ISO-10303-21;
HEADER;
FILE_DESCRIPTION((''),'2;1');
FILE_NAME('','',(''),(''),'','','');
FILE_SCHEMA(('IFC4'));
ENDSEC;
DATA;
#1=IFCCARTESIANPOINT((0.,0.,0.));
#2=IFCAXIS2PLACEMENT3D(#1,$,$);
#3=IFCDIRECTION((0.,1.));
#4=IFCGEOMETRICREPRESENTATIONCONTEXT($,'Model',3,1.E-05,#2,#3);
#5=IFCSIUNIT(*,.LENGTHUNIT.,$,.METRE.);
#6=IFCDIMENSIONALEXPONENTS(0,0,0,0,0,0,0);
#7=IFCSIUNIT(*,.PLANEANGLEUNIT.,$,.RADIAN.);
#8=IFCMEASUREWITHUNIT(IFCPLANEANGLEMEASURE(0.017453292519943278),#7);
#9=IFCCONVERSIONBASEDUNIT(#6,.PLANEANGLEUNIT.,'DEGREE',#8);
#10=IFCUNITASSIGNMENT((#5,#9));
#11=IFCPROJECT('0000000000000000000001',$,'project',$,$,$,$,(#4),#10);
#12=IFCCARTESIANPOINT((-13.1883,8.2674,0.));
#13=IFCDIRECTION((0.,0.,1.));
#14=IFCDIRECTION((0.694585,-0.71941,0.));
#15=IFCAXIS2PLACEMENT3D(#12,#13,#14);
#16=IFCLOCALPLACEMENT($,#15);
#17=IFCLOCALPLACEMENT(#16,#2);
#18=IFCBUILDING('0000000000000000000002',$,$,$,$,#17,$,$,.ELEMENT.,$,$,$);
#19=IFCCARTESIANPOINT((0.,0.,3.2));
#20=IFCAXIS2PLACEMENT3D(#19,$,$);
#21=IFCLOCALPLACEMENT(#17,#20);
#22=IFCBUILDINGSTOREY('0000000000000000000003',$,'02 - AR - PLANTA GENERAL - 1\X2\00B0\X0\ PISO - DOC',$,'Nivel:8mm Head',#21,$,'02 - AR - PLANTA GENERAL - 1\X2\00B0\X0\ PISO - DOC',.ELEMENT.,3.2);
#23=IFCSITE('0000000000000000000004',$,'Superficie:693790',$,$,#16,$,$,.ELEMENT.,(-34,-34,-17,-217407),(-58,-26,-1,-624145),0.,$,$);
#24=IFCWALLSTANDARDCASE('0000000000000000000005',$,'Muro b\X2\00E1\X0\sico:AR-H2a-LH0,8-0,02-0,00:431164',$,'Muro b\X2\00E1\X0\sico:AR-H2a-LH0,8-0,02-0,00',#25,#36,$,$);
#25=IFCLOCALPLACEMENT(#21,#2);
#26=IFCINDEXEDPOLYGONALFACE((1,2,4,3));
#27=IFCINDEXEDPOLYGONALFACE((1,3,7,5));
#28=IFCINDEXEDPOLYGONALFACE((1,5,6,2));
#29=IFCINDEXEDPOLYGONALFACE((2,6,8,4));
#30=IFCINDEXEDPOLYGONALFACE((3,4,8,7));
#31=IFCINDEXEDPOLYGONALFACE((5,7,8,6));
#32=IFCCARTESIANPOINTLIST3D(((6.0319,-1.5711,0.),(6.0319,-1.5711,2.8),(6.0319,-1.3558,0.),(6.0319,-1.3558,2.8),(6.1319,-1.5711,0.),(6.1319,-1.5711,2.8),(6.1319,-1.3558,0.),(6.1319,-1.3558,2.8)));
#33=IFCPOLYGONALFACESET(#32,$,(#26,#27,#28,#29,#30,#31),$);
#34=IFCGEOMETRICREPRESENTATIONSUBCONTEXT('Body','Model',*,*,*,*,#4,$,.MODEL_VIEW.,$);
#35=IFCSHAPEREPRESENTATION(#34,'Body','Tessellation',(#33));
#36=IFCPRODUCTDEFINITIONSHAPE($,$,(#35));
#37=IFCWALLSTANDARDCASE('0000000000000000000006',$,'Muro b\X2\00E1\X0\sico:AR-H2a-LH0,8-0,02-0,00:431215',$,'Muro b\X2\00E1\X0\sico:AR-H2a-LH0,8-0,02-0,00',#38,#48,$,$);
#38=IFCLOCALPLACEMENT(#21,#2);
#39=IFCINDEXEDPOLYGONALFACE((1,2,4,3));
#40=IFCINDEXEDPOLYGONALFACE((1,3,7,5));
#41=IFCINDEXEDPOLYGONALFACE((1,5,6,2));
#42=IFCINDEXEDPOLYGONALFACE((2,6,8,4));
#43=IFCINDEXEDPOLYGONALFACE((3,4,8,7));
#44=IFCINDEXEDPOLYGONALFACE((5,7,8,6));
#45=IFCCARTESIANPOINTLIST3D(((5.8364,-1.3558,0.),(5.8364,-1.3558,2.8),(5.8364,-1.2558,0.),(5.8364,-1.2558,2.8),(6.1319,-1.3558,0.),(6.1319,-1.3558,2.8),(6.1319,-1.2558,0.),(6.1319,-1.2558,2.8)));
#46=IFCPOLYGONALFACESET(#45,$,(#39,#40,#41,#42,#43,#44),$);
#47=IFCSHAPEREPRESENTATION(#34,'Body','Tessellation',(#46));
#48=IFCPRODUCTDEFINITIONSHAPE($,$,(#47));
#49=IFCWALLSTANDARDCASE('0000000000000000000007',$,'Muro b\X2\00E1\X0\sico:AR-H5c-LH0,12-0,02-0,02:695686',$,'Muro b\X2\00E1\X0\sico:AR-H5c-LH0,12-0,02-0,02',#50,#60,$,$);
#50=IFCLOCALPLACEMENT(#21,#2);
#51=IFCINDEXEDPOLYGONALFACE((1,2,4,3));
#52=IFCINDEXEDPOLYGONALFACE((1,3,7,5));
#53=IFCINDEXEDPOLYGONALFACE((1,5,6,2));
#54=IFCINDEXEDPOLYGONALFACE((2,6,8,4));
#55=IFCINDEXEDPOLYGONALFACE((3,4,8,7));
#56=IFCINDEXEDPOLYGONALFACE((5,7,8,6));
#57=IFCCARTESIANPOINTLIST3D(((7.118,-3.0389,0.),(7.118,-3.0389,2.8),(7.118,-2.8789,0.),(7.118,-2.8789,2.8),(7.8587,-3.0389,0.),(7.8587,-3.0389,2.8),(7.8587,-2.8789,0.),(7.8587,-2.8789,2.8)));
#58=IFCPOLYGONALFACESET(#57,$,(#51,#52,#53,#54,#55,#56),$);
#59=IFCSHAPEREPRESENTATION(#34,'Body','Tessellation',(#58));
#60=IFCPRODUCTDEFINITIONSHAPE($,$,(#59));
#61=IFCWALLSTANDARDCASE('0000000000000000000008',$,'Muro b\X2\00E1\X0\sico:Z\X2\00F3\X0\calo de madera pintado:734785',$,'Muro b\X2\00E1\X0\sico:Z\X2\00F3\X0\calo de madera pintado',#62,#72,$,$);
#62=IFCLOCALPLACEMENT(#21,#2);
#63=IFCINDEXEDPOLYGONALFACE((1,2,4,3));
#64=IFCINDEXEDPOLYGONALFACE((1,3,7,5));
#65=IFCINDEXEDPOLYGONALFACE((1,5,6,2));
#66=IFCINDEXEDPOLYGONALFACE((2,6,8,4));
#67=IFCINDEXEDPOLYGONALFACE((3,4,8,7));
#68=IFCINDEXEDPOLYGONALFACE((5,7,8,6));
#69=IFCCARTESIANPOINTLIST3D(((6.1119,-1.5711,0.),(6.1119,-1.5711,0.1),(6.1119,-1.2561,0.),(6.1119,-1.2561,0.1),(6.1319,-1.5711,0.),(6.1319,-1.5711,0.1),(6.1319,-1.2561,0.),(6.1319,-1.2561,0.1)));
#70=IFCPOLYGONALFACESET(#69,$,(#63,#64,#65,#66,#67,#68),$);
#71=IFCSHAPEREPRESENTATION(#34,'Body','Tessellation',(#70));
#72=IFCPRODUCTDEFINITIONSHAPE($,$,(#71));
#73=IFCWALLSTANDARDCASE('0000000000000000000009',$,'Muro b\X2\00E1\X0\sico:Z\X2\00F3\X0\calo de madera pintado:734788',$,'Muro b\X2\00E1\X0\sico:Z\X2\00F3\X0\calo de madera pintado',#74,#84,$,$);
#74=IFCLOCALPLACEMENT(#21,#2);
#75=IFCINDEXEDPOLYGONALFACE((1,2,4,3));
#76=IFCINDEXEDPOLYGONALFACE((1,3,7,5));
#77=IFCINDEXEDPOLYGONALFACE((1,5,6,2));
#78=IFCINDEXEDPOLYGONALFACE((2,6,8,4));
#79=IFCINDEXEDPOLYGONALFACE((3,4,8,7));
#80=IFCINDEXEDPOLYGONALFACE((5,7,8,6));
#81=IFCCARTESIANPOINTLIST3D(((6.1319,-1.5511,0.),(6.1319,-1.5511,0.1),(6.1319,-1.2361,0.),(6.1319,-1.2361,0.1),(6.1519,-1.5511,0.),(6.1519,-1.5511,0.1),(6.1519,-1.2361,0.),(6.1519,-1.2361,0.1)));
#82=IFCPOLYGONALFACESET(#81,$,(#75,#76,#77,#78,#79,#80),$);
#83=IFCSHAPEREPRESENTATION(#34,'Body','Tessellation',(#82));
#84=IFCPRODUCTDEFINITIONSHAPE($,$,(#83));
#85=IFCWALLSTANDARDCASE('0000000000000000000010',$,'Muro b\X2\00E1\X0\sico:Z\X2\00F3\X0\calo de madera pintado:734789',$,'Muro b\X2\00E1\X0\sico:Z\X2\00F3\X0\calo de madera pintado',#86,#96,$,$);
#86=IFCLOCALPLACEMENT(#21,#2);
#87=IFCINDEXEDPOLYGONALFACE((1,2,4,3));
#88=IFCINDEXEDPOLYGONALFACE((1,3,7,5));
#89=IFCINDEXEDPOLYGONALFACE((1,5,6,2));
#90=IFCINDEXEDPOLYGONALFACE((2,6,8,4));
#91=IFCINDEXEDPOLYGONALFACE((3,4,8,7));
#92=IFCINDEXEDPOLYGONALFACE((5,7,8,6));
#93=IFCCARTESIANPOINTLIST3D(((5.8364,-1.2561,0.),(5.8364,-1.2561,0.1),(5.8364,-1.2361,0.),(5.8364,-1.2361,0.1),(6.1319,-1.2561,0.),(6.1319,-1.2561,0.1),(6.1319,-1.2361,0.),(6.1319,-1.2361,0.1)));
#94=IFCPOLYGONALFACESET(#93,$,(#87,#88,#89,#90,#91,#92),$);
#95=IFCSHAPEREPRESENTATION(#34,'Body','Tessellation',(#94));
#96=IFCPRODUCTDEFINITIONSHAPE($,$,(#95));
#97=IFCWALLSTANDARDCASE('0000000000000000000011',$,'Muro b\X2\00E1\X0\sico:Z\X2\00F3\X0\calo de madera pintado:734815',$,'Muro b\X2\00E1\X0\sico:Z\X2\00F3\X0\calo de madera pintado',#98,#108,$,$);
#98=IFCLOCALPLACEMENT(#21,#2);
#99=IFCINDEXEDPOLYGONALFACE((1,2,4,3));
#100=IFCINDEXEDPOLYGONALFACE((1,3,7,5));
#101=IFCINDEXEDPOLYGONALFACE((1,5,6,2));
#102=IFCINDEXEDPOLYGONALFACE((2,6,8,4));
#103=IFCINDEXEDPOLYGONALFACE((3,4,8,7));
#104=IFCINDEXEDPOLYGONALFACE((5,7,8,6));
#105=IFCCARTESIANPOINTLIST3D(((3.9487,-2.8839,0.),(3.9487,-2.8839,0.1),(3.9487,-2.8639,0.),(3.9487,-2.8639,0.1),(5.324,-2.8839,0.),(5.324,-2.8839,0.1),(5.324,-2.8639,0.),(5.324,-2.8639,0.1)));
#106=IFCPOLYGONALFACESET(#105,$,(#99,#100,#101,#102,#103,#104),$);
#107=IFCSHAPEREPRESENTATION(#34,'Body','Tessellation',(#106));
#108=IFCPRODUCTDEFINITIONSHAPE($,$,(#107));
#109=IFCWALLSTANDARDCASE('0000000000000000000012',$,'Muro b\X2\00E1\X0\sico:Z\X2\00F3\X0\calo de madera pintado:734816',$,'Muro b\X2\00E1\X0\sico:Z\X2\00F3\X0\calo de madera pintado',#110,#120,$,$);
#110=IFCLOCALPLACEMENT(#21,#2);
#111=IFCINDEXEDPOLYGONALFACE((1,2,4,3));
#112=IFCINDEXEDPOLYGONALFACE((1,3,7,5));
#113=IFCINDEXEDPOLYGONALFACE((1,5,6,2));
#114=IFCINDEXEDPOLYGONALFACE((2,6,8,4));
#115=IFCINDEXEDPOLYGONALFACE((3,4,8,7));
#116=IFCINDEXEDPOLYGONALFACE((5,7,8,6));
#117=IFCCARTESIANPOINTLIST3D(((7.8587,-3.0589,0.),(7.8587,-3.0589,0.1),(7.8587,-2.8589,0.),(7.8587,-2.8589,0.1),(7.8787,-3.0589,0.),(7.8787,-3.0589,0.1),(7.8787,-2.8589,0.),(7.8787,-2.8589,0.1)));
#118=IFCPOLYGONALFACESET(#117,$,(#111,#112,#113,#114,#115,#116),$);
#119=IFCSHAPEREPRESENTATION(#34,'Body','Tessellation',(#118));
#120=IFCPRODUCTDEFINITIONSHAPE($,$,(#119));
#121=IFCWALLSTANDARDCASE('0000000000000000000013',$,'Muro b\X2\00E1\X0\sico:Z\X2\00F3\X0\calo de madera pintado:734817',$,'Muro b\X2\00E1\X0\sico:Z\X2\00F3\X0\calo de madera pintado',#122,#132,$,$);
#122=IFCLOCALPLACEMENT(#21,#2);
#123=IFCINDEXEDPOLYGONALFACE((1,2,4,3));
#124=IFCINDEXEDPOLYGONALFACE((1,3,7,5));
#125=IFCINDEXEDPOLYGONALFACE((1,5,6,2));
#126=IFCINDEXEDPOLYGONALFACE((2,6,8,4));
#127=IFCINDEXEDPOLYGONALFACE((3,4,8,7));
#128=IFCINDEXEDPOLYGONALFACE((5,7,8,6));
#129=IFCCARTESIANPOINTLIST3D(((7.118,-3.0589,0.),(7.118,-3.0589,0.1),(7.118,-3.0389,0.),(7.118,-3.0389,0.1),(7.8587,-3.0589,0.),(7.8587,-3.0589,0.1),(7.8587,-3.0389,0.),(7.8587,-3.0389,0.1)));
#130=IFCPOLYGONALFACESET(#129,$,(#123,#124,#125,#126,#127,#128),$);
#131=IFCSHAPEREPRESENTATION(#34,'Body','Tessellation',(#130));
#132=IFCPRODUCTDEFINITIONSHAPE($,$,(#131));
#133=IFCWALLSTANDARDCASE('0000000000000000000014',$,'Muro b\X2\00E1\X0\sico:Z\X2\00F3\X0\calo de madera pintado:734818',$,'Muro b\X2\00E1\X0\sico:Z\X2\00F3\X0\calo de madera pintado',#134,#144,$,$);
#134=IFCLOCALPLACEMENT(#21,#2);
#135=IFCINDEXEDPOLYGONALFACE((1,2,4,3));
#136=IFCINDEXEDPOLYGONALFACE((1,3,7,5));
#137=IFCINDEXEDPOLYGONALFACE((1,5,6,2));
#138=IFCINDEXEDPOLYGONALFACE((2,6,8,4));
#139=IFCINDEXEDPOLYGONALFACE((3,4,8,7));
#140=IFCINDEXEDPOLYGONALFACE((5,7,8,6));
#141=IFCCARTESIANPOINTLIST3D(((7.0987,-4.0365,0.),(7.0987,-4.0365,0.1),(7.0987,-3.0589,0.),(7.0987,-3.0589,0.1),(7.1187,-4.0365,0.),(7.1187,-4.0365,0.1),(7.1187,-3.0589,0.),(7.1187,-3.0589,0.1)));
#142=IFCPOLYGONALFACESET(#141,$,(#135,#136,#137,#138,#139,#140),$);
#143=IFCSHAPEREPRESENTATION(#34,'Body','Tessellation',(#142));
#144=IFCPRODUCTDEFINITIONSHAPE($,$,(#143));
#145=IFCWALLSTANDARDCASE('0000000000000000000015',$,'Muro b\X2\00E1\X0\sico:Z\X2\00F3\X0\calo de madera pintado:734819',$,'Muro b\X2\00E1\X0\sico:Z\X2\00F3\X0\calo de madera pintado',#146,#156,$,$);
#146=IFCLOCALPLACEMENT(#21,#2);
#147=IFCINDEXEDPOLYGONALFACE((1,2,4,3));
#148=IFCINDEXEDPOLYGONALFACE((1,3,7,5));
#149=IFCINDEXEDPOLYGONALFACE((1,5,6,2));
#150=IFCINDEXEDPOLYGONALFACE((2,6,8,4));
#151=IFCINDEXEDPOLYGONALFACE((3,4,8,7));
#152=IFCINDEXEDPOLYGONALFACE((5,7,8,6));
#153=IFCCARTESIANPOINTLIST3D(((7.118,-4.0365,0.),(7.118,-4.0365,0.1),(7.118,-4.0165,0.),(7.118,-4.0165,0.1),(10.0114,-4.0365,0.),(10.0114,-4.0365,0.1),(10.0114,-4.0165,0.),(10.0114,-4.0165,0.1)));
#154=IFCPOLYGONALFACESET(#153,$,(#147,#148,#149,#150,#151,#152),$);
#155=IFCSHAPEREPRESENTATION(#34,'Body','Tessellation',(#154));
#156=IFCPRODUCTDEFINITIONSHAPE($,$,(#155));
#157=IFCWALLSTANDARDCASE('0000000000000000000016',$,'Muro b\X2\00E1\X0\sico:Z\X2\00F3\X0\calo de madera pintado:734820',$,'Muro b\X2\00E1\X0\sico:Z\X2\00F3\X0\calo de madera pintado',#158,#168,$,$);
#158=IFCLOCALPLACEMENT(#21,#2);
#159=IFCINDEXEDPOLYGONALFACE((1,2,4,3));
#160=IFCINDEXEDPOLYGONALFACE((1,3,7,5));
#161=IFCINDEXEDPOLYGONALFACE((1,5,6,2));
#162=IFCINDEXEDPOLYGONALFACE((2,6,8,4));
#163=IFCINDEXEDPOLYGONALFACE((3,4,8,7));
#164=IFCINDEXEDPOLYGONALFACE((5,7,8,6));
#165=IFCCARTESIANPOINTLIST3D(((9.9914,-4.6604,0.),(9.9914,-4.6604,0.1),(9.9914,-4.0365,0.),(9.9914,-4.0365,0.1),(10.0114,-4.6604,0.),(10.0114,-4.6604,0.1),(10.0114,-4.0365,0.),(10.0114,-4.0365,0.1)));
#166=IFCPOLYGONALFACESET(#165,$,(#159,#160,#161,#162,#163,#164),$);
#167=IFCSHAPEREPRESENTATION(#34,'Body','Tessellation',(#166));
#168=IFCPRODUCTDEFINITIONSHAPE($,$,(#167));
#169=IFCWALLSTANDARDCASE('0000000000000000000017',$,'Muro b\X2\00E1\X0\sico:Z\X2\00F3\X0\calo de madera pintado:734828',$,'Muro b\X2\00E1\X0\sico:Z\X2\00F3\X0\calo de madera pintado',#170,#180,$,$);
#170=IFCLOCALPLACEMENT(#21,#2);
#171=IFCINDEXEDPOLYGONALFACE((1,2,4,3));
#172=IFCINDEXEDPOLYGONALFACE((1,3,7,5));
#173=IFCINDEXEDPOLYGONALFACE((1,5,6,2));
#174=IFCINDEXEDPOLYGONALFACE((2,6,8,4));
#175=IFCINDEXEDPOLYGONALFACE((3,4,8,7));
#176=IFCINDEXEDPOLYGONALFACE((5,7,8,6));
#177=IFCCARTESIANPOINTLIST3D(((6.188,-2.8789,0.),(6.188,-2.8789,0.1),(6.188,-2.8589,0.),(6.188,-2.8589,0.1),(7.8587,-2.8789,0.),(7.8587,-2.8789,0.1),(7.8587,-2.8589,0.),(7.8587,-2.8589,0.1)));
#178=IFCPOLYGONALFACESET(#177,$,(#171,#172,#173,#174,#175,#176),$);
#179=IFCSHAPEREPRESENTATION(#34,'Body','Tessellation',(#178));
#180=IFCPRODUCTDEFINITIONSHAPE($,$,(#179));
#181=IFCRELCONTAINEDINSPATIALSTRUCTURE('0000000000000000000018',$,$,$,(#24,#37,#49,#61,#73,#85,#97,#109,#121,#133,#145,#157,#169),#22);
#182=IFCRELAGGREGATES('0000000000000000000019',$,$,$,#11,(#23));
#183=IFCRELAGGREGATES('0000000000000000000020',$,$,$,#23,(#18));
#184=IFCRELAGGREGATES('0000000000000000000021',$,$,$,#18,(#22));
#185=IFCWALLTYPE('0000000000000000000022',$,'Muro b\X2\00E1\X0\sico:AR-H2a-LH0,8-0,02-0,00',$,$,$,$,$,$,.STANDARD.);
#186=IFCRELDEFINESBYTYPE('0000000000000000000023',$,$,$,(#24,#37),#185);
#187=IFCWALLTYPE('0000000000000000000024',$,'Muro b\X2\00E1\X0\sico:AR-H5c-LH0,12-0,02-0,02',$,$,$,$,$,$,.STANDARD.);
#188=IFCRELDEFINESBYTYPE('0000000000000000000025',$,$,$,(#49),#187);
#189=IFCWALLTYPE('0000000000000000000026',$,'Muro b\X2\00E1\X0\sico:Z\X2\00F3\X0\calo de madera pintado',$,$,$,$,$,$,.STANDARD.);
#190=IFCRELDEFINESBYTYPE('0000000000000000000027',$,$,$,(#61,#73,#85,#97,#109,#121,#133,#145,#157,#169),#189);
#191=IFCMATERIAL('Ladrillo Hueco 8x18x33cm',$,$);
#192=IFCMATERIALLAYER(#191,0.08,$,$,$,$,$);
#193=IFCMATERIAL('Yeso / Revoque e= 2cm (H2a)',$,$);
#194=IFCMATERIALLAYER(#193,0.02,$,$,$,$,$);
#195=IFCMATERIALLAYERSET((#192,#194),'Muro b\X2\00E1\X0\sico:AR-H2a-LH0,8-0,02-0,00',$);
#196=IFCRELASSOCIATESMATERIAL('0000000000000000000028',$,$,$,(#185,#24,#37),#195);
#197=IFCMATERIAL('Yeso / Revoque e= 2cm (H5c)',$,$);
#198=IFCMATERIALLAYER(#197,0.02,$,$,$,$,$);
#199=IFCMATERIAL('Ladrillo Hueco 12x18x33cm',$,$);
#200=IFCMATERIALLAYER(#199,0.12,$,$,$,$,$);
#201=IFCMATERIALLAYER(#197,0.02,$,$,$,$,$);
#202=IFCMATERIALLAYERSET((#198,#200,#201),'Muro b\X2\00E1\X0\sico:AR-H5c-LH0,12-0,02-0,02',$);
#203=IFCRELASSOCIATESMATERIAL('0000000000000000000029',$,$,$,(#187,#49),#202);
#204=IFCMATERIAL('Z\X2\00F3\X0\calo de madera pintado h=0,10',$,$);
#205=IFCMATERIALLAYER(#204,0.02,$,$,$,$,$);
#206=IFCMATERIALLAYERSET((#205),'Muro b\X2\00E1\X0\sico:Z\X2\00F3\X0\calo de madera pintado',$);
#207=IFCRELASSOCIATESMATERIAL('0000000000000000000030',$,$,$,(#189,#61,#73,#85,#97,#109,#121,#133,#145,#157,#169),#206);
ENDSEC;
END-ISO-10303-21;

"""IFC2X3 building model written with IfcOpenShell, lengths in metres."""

from ifc_helpers import new_model, entity, si_unit, converted_unit, direction, frame, frame_2d, origin, place, context, subcontext, project, spatial, rectangle, extrude, material, layer, layer_set, layer_usage, type_object, element, save


model = new_model("IFC2X3")

# Units and contexts
model_context = context("Model", 3, precision=1e-05, world=origin(), true_north=direction((0.0, 1.0)))
body_context = subcontext(model_context, "Body", "Model", "MODEL_VIEW")
ifc_project = project(units=[si_unit("LENGTHUNIT", "METRE"), converted_unit("PLANEANGLEUNIT", "DEGREE", entity("IfcPlaneAngleMeasure", 0.017453292519943278), si_unit("PLANEANGLEUNIT", "RADIAN"), dimensions=[0, 0, 0, 0, 0, 0, 0])], contexts=[model_context])

# Site, building, storey
site_placement = place(None, frame((-13.1883, 8.2674, 0.0), z_axis=(0.0, 0.0, 1.0), x_axis=(0.694585, -0.71941, 0.0)))
site = spatial("IfcSite", under=ifc_project, at=site_placement, Name="Superficie:693790", CompositionType="ELEMENT", RefLatitude=(-34, -34, -17, -217407), RefLongitude=(-58, -26, -1, -624145), RefElevation=0.0)
building_placement = place(site_placement, origin())
building = spatial("IfcBuilding", under=site, at=building_placement, CompositionType="ELEMENT")
storey_placement = place(building_placement, frame((0.0, 0.0, 3.2)))
storey = spatial("IfcBuildingStorey", under=building, at=storey_placement, Name="02 - AR - PLANTA GENERAL - 1° PISO - DOC", ObjectType="Nivel:8mm Head", LongName="02 - AR - PLANTA GENERAL - 1° PISO - DOC", CompositionType="ELEMENT", Elevation=3.2)

# Shared definitions
ifc_material_1 = material(Name="Ladrillo Hueco 8x18x33cm")

# Walls
ifc_layer_1 = layer(ifc_material_1, 0.08)
ifc_material_2 = material(Name="Yeso / Revoque e= 2cm (H2a)")
ifc_layer_2 = layer(ifc_material_2, 0.02)
ifc_layer_set_1 = layer_set([ifc_layer_1, ifc_layer_2], Name="Muro básico:AR-H2a-LH0,8-0,02-0,00")
wall_type_1 = type_object("IfcWallType", Name="Muro básico:AR-H2a-LH0,8-0,02-0,00", PredefinedType="STANDARD", material=ifc_layer_set_1)
ifc_layer_usage_1 = layer_usage(ifc_layer_set_1, "AXIS2", "NEGATIVE", 0.05)
wall_1_placement = place(storey_placement, frame((6.0819, -1.5711, 0.0), z_axis=(0.0, 0.0, 1.0), x_axis=(0.0, 1.0, 0.0)))
element("IfcWallStandardCase", 1, at=wall_1_placement, inside=storey, type_object=wall_type_1, material=ifc_layer_usage_1, Name="Muro básico:AR-H2a-LH0,8-0,02-0,00:431164", ObjectType="Muro básico:AR-H2a-LH0,8-0,02-0,00", context=body_context, shape_type="SweptSolid", body=[
    extrude(rectangle(XDim=0.2153, YDim=0.1, at=frame_2d((0.1076, 0.0), x_axis=(-1.0, 0.0))), origin(), (0.0, 0.0, 1.0), 2.8),
])
ifc_layer_usage_2 = layer_usage(ifc_layer_set_1, "AXIS2", "NEGATIVE", 0.05)
wall_2_placement = place(storey_placement, frame((6.1319, -1.3058, 0.0), z_axis=(0.0, 0.0, 1.0), x_axis=(-1.0, 0.0, 0.0)))
element("IfcWallStandardCase", 2, at=wall_2_placement, inside=storey, type_object=wall_type_1, material=ifc_layer_usage_2, Name="Muro básico:AR-H2a-LH0,8-0,02-0,00:431215", ObjectType="Muro básico:AR-H2a-LH0,8-0,02-0,00", context=body_context, shape_type="SweptSolid", body=[
    extrude(rectangle(XDim=0.2955, YDim=0.1, at=frame_2d((0.1477, 0.0), x_axis=(-1.0, 0.0))), origin(), (0.0, 0.0, 1.0), 2.8),
])
ifc_material_3 = material(Name="Yeso / Revoque e= 2cm (H5c)")
ifc_layer_3 = layer(ifc_material_3, 0.02)
ifc_material_4 = material(Name="Ladrillo Hueco 12x18x33cm")
ifc_layer_4 = layer(ifc_material_4, 0.12)
ifc_layer_5 = layer(ifc_material_3, 0.02)
ifc_layer_set_2 = layer_set([ifc_layer_3, ifc_layer_4, ifc_layer_5], Name="Muro básico:AR-H5c-LH0,12-0,02-0,02")
ifc_layer_usage_3 = layer_usage(ifc_layer_set_2, "AXIS2", "NEGATIVE", 0.08)
wall_type_2 = type_object("IfcWallType", Name="Muro básico:AR-H5c-LH0,12-0,02-0,02", PredefinedType="STANDARD", material=ifc_layer_set_2)
wall_3_placement = place(storey_placement, frame((7.118, -2.9589, 0.0)))
element("IfcWallStandardCase", 3, at=wall_3_placement, inside=storey, type_object=wall_type_2, material=ifc_layer_usage_3, Name="Muro básico:AR-H5c-LH0,12-0,02-0,02:695686", ObjectType="Muro básico:AR-H5c-LH0,12-0,02-0,02", context=body_context, shape_type="SweptSolid", body=[
    extrude(rectangle(XDim=0.7407, YDim=0.16, at=frame_2d((0.3704, 0.0), x_axis=(-1.0, 0.0))), origin(), (0.0, 0.0, 1.0), 2.8),
])
ifc_material_5 = material(Name="Zócalo de madera pintado h=0,10")
ifc_layer_6 = layer(ifc_material_5, 0.02)
ifc_layer_set_3 = layer_set([ifc_layer_6], Name="Muro básico:Zócalo de madera pintado")
ifc_layer_usage_4 = layer_usage(ifc_layer_set_3, "AXIS2", "NEGATIVE", 0.01)
wall_type_3 = type_object("IfcWallType", Name="Muro básico:Zócalo de madera pintado", PredefinedType="STANDARD", material=ifc_layer_set_3)
wall_4_placement = place(storey_placement, frame((6.1219, -1.2561, 0.0), z_axis=(0.0, 0.0, 1.0), x_axis=(0.0, -1.0, 0.0)))
element("IfcWallStandardCase", 4, at=wall_4_placement, inside=storey, type_object=wall_type_3, material=ifc_layer_usage_4, Name="Muro básico:Zócalo de madera pintado:734785", ObjectType="Muro básico:Zócalo de madera pintado", context=body_context, shape_type="SweptSolid", body=[
    extrude(rectangle(XDim=0.315, YDim=0.02, at=frame_2d((0.1575, 0.0), x_axis=(-1.0, 0.0))), origin(), (0.0, 0.0, 1.0), 0.1),
])
ifc_layer_usage_5 = layer_usage(ifc_layer_set_3, "AXIS2", "NEGATIVE", 0.01)
wall_5_placement = place(storey_placement, frame((6.1419, -1.5511, 0.0), z_axis=(0.0, 0.0, 1.0), x_axis=(0.0, 1.0, 0.0)))
element("IfcWallStandardCase", 5, at=wall_5_placement, inside=storey, type_object=wall_type_3, material=ifc_layer_usage_5, Name="Muro básico:Zócalo de madera pintado:734788", ObjectType="Muro básico:Zócalo de madera pintado", context=body_context, shape_type="SweptSolid", body=[
    extrude(rectangle(XDim=0.315, YDim=0.02, at=frame_2d((0.1575, 0.0), x_axis=(-1.0, 0.0))), origin(), (0.0, 0.0, 1.0), 0.1),
])
ifc_layer_usage_6 = layer_usage(ifc_layer_set_3, "AXIS2", "NEGATIVE", 0.01)
wall_6_placement = place(storey_placement, frame((6.1319, -1.2461, 0.0), z_axis=(0.0, 0.0, 1.0), x_axis=(-1.0, 0.0, 0.0)))
element("IfcWallStandardCase", 6, at=wall_6_placement, inside=storey, type_object=wall_type_3, material=ifc_layer_usage_6, Name="Muro básico:Zócalo de madera pintado:734789", ObjectType="Muro básico:Zócalo de madera pintado", context=body_context, shape_type="SweptSolid", body=[
    extrude(rectangle(XDim=0.2955, YDim=0.02, at=frame_2d((0.1477, 0.0), x_axis=(-1.0, 0.0))), origin(), (0.0, 0.0, 1.0), 0.1),
])
ifc_layer_usage_7 = layer_usage(ifc_layer_set_3, "AXIS2", "NEGATIVE", 0.01)
wall_7_placement = place(storey_placement, frame((5.324, -2.8739, 0.0), z_axis=(0.0, 0.0, 1.0), x_axis=(-1.0, 0.0, 0.0)))
element("IfcWallStandardCase", 7, at=wall_7_placement, inside=storey, type_object=wall_type_3, material=ifc_layer_usage_7, Name="Muro básico:Zócalo de madera pintado:734815", ObjectType="Muro básico:Zócalo de madera pintado", context=body_context, shape_type="SweptSolid", body=[
    extrude(rectangle(XDim=1.3753, YDim=0.02, at=frame_2d((0.6876, 0.0), x_axis=(-1.0, 0.0))), origin(), (0.0, 0.0, 1.0), 0.1),
])
ifc_layer_usage_8 = layer_usage(ifc_layer_set_3, "AXIS2", "NEGATIVE", 0.01)
wall_8_placement = place(storey_placement, frame((7.8687, -3.0589, 0.0), z_axis=(0.0, 0.0, 1.0), x_axis=(0.0, 1.0, 0.0)))
element("IfcWallStandardCase", 8, at=wall_8_placement, inside=storey, type_object=wall_type_3, material=ifc_layer_usage_8, Name="Muro básico:Zócalo de madera pintado:734816", ObjectType="Muro básico:Zócalo de madera pintado", context=body_context, shape_type="SweptSolid", body=[
    extrude(rectangle(XDim=0.2, YDim=0.02, at=frame_2d((0.1, 0.0), x_axis=(-1.0, 0.0))), origin(), (0.0, 0.0, 1.0), 0.1),
])
ifc_layer_usage_9 = layer_usage(ifc_layer_set_3, "AXIS2", "NEGATIVE", 0.01)
wall_9_placement = place(storey_placement, frame((7.118, -3.0489, 0.0)))
element("IfcWallStandardCase", 9, at=wall_9_placement, inside=storey, type_object=wall_type_3, material=ifc_layer_usage_9, Name="Muro básico:Zócalo de madera pintado:734817", ObjectType="Muro básico:Zócalo de madera pintado", context=body_context, shape_type="SweptSolid", body=[
    extrude(rectangle(XDim=0.7407, YDim=0.02, at=frame_2d((0.3704, 0.0), x_axis=(-1.0, 0.0))), origin(), (0.0, 0.0, 1.0), 0.1),
])
ifc_layer_usage_10 = layer_usage(ifc_layer_set_3, "AXIS2", "NEGATIVE", 0.01)
wall_10_placement = place(storey_placement, frame((7.1087, -4.0365, 0.0), z_axis=(0.0, 0.0, 1.0), x_axis=(0.0, 1.0, 0.0)))
element("IfcWallStandardCase", 10, at=wall_10_placement, inside=storey, type_object=wall_type_3, material=ifc_layer_usage_10, Name="Muro básico:Zócalo de madera pintado:734818", ObjectType="Muro básico:Zócalo de madera pintado", context=body_context, shape_type="SweptSolid", body=[
    extrude(rectangle(XDim=0.9776, YDim=0.02, at=frame_2d((0.4888, 0.0), x_axis=(-1.0, 0.0))), origin(), (0.0, 0.0, 1.0), 0.1),
])
ifc_layer_usage_11 = layer_usage(ifc_layer_set_3, "AXIS2", "NEGATIVE", 0.01)
wall_11_placement = place(storey_placement, frame((10.0114, -4.0265, 0.0), z_axis=(0.0, 0.0, 1.0), x_axis=(-1.0, 0.0, 0.0)))
element("IfcWallStandardCase", 11, at=wall_11_placement, inside=storey, type_object=wall_type_3, material=ifc_layer_usage_11, Name="Muro básico:Zócalo de madera pintado:734819", ObjectType="Muro básico:Zócalo de madera pintado", context=body_context, shape_type="SweptSolid", body=[
    extrude(rectangle(XDim=2.8934, YDim=0.02, at=frame_2d((1.4467, 0.0), x_axis=(-1.0, 0.0))), origin(), (0.0, 0.0, 1.0), 0.1),
])
ifc_layer_usage_12 = layer_usage(ifc_layer_set_3, "AXIS2", "NEGATIVE", 0.01)
wall_12_placement = place(storey_placement, frame((10.0014, -4.6604, 0.0), z_axis=(0.0, 0.0, 1.0), x_axis=(0.0, 1.0, 0.0)))
element("IfcWallStandardCase", 12, at=wall_12_placement, inside=storey, type_object=wall_type_3, material=ifc_layer_usage_12, Name="Muro básico:Zócalo de madera pintado:734820", ObjectType="Muro básico:Zócalo de madera pintado", context=body_context, shape_type="SweptSolid", body=[
    extrude(rectangle(XDim=0.6239, YDim=0.02, at=frame_2d((0.312, 0.0), x_axis=(-1.0, 0.0))), origin(), (0.0, 0.0, 1.0), 0.1),
])
ifc_layer_usage_13 = layer_usage(ifc_layer_set_3, "AXIS2", "NEGATIVE", 0.01)
wall_13_placement = place(storey_placement, frame((7.8587, -2.8689, 0.0), z_axis=(0.0, 0.0, 1.0), x_axis=(-1.0, 0.0, 0.0)))
element("IfcWallStandardCase", 13, at=wall_13_placement, inside=storey, type_object=wall_type_3, material=ifc_layer_usage_13, Name="Muro básico:Zócalo de madera pintado:734828", ObjectType="Muro básico:Zócalo de madera pintado", context=body_context, shape_type="SweptSolid", body=[
    extrude(rectangle(XDim=1.6707, YDim=0.02, at=frame_2d((0.8354, 0.0), x_axis=(-1.0, 0.0))), origin(), (0.0, 0.0, 1.0), 0.1),
])

save(model, "model.ifc")
